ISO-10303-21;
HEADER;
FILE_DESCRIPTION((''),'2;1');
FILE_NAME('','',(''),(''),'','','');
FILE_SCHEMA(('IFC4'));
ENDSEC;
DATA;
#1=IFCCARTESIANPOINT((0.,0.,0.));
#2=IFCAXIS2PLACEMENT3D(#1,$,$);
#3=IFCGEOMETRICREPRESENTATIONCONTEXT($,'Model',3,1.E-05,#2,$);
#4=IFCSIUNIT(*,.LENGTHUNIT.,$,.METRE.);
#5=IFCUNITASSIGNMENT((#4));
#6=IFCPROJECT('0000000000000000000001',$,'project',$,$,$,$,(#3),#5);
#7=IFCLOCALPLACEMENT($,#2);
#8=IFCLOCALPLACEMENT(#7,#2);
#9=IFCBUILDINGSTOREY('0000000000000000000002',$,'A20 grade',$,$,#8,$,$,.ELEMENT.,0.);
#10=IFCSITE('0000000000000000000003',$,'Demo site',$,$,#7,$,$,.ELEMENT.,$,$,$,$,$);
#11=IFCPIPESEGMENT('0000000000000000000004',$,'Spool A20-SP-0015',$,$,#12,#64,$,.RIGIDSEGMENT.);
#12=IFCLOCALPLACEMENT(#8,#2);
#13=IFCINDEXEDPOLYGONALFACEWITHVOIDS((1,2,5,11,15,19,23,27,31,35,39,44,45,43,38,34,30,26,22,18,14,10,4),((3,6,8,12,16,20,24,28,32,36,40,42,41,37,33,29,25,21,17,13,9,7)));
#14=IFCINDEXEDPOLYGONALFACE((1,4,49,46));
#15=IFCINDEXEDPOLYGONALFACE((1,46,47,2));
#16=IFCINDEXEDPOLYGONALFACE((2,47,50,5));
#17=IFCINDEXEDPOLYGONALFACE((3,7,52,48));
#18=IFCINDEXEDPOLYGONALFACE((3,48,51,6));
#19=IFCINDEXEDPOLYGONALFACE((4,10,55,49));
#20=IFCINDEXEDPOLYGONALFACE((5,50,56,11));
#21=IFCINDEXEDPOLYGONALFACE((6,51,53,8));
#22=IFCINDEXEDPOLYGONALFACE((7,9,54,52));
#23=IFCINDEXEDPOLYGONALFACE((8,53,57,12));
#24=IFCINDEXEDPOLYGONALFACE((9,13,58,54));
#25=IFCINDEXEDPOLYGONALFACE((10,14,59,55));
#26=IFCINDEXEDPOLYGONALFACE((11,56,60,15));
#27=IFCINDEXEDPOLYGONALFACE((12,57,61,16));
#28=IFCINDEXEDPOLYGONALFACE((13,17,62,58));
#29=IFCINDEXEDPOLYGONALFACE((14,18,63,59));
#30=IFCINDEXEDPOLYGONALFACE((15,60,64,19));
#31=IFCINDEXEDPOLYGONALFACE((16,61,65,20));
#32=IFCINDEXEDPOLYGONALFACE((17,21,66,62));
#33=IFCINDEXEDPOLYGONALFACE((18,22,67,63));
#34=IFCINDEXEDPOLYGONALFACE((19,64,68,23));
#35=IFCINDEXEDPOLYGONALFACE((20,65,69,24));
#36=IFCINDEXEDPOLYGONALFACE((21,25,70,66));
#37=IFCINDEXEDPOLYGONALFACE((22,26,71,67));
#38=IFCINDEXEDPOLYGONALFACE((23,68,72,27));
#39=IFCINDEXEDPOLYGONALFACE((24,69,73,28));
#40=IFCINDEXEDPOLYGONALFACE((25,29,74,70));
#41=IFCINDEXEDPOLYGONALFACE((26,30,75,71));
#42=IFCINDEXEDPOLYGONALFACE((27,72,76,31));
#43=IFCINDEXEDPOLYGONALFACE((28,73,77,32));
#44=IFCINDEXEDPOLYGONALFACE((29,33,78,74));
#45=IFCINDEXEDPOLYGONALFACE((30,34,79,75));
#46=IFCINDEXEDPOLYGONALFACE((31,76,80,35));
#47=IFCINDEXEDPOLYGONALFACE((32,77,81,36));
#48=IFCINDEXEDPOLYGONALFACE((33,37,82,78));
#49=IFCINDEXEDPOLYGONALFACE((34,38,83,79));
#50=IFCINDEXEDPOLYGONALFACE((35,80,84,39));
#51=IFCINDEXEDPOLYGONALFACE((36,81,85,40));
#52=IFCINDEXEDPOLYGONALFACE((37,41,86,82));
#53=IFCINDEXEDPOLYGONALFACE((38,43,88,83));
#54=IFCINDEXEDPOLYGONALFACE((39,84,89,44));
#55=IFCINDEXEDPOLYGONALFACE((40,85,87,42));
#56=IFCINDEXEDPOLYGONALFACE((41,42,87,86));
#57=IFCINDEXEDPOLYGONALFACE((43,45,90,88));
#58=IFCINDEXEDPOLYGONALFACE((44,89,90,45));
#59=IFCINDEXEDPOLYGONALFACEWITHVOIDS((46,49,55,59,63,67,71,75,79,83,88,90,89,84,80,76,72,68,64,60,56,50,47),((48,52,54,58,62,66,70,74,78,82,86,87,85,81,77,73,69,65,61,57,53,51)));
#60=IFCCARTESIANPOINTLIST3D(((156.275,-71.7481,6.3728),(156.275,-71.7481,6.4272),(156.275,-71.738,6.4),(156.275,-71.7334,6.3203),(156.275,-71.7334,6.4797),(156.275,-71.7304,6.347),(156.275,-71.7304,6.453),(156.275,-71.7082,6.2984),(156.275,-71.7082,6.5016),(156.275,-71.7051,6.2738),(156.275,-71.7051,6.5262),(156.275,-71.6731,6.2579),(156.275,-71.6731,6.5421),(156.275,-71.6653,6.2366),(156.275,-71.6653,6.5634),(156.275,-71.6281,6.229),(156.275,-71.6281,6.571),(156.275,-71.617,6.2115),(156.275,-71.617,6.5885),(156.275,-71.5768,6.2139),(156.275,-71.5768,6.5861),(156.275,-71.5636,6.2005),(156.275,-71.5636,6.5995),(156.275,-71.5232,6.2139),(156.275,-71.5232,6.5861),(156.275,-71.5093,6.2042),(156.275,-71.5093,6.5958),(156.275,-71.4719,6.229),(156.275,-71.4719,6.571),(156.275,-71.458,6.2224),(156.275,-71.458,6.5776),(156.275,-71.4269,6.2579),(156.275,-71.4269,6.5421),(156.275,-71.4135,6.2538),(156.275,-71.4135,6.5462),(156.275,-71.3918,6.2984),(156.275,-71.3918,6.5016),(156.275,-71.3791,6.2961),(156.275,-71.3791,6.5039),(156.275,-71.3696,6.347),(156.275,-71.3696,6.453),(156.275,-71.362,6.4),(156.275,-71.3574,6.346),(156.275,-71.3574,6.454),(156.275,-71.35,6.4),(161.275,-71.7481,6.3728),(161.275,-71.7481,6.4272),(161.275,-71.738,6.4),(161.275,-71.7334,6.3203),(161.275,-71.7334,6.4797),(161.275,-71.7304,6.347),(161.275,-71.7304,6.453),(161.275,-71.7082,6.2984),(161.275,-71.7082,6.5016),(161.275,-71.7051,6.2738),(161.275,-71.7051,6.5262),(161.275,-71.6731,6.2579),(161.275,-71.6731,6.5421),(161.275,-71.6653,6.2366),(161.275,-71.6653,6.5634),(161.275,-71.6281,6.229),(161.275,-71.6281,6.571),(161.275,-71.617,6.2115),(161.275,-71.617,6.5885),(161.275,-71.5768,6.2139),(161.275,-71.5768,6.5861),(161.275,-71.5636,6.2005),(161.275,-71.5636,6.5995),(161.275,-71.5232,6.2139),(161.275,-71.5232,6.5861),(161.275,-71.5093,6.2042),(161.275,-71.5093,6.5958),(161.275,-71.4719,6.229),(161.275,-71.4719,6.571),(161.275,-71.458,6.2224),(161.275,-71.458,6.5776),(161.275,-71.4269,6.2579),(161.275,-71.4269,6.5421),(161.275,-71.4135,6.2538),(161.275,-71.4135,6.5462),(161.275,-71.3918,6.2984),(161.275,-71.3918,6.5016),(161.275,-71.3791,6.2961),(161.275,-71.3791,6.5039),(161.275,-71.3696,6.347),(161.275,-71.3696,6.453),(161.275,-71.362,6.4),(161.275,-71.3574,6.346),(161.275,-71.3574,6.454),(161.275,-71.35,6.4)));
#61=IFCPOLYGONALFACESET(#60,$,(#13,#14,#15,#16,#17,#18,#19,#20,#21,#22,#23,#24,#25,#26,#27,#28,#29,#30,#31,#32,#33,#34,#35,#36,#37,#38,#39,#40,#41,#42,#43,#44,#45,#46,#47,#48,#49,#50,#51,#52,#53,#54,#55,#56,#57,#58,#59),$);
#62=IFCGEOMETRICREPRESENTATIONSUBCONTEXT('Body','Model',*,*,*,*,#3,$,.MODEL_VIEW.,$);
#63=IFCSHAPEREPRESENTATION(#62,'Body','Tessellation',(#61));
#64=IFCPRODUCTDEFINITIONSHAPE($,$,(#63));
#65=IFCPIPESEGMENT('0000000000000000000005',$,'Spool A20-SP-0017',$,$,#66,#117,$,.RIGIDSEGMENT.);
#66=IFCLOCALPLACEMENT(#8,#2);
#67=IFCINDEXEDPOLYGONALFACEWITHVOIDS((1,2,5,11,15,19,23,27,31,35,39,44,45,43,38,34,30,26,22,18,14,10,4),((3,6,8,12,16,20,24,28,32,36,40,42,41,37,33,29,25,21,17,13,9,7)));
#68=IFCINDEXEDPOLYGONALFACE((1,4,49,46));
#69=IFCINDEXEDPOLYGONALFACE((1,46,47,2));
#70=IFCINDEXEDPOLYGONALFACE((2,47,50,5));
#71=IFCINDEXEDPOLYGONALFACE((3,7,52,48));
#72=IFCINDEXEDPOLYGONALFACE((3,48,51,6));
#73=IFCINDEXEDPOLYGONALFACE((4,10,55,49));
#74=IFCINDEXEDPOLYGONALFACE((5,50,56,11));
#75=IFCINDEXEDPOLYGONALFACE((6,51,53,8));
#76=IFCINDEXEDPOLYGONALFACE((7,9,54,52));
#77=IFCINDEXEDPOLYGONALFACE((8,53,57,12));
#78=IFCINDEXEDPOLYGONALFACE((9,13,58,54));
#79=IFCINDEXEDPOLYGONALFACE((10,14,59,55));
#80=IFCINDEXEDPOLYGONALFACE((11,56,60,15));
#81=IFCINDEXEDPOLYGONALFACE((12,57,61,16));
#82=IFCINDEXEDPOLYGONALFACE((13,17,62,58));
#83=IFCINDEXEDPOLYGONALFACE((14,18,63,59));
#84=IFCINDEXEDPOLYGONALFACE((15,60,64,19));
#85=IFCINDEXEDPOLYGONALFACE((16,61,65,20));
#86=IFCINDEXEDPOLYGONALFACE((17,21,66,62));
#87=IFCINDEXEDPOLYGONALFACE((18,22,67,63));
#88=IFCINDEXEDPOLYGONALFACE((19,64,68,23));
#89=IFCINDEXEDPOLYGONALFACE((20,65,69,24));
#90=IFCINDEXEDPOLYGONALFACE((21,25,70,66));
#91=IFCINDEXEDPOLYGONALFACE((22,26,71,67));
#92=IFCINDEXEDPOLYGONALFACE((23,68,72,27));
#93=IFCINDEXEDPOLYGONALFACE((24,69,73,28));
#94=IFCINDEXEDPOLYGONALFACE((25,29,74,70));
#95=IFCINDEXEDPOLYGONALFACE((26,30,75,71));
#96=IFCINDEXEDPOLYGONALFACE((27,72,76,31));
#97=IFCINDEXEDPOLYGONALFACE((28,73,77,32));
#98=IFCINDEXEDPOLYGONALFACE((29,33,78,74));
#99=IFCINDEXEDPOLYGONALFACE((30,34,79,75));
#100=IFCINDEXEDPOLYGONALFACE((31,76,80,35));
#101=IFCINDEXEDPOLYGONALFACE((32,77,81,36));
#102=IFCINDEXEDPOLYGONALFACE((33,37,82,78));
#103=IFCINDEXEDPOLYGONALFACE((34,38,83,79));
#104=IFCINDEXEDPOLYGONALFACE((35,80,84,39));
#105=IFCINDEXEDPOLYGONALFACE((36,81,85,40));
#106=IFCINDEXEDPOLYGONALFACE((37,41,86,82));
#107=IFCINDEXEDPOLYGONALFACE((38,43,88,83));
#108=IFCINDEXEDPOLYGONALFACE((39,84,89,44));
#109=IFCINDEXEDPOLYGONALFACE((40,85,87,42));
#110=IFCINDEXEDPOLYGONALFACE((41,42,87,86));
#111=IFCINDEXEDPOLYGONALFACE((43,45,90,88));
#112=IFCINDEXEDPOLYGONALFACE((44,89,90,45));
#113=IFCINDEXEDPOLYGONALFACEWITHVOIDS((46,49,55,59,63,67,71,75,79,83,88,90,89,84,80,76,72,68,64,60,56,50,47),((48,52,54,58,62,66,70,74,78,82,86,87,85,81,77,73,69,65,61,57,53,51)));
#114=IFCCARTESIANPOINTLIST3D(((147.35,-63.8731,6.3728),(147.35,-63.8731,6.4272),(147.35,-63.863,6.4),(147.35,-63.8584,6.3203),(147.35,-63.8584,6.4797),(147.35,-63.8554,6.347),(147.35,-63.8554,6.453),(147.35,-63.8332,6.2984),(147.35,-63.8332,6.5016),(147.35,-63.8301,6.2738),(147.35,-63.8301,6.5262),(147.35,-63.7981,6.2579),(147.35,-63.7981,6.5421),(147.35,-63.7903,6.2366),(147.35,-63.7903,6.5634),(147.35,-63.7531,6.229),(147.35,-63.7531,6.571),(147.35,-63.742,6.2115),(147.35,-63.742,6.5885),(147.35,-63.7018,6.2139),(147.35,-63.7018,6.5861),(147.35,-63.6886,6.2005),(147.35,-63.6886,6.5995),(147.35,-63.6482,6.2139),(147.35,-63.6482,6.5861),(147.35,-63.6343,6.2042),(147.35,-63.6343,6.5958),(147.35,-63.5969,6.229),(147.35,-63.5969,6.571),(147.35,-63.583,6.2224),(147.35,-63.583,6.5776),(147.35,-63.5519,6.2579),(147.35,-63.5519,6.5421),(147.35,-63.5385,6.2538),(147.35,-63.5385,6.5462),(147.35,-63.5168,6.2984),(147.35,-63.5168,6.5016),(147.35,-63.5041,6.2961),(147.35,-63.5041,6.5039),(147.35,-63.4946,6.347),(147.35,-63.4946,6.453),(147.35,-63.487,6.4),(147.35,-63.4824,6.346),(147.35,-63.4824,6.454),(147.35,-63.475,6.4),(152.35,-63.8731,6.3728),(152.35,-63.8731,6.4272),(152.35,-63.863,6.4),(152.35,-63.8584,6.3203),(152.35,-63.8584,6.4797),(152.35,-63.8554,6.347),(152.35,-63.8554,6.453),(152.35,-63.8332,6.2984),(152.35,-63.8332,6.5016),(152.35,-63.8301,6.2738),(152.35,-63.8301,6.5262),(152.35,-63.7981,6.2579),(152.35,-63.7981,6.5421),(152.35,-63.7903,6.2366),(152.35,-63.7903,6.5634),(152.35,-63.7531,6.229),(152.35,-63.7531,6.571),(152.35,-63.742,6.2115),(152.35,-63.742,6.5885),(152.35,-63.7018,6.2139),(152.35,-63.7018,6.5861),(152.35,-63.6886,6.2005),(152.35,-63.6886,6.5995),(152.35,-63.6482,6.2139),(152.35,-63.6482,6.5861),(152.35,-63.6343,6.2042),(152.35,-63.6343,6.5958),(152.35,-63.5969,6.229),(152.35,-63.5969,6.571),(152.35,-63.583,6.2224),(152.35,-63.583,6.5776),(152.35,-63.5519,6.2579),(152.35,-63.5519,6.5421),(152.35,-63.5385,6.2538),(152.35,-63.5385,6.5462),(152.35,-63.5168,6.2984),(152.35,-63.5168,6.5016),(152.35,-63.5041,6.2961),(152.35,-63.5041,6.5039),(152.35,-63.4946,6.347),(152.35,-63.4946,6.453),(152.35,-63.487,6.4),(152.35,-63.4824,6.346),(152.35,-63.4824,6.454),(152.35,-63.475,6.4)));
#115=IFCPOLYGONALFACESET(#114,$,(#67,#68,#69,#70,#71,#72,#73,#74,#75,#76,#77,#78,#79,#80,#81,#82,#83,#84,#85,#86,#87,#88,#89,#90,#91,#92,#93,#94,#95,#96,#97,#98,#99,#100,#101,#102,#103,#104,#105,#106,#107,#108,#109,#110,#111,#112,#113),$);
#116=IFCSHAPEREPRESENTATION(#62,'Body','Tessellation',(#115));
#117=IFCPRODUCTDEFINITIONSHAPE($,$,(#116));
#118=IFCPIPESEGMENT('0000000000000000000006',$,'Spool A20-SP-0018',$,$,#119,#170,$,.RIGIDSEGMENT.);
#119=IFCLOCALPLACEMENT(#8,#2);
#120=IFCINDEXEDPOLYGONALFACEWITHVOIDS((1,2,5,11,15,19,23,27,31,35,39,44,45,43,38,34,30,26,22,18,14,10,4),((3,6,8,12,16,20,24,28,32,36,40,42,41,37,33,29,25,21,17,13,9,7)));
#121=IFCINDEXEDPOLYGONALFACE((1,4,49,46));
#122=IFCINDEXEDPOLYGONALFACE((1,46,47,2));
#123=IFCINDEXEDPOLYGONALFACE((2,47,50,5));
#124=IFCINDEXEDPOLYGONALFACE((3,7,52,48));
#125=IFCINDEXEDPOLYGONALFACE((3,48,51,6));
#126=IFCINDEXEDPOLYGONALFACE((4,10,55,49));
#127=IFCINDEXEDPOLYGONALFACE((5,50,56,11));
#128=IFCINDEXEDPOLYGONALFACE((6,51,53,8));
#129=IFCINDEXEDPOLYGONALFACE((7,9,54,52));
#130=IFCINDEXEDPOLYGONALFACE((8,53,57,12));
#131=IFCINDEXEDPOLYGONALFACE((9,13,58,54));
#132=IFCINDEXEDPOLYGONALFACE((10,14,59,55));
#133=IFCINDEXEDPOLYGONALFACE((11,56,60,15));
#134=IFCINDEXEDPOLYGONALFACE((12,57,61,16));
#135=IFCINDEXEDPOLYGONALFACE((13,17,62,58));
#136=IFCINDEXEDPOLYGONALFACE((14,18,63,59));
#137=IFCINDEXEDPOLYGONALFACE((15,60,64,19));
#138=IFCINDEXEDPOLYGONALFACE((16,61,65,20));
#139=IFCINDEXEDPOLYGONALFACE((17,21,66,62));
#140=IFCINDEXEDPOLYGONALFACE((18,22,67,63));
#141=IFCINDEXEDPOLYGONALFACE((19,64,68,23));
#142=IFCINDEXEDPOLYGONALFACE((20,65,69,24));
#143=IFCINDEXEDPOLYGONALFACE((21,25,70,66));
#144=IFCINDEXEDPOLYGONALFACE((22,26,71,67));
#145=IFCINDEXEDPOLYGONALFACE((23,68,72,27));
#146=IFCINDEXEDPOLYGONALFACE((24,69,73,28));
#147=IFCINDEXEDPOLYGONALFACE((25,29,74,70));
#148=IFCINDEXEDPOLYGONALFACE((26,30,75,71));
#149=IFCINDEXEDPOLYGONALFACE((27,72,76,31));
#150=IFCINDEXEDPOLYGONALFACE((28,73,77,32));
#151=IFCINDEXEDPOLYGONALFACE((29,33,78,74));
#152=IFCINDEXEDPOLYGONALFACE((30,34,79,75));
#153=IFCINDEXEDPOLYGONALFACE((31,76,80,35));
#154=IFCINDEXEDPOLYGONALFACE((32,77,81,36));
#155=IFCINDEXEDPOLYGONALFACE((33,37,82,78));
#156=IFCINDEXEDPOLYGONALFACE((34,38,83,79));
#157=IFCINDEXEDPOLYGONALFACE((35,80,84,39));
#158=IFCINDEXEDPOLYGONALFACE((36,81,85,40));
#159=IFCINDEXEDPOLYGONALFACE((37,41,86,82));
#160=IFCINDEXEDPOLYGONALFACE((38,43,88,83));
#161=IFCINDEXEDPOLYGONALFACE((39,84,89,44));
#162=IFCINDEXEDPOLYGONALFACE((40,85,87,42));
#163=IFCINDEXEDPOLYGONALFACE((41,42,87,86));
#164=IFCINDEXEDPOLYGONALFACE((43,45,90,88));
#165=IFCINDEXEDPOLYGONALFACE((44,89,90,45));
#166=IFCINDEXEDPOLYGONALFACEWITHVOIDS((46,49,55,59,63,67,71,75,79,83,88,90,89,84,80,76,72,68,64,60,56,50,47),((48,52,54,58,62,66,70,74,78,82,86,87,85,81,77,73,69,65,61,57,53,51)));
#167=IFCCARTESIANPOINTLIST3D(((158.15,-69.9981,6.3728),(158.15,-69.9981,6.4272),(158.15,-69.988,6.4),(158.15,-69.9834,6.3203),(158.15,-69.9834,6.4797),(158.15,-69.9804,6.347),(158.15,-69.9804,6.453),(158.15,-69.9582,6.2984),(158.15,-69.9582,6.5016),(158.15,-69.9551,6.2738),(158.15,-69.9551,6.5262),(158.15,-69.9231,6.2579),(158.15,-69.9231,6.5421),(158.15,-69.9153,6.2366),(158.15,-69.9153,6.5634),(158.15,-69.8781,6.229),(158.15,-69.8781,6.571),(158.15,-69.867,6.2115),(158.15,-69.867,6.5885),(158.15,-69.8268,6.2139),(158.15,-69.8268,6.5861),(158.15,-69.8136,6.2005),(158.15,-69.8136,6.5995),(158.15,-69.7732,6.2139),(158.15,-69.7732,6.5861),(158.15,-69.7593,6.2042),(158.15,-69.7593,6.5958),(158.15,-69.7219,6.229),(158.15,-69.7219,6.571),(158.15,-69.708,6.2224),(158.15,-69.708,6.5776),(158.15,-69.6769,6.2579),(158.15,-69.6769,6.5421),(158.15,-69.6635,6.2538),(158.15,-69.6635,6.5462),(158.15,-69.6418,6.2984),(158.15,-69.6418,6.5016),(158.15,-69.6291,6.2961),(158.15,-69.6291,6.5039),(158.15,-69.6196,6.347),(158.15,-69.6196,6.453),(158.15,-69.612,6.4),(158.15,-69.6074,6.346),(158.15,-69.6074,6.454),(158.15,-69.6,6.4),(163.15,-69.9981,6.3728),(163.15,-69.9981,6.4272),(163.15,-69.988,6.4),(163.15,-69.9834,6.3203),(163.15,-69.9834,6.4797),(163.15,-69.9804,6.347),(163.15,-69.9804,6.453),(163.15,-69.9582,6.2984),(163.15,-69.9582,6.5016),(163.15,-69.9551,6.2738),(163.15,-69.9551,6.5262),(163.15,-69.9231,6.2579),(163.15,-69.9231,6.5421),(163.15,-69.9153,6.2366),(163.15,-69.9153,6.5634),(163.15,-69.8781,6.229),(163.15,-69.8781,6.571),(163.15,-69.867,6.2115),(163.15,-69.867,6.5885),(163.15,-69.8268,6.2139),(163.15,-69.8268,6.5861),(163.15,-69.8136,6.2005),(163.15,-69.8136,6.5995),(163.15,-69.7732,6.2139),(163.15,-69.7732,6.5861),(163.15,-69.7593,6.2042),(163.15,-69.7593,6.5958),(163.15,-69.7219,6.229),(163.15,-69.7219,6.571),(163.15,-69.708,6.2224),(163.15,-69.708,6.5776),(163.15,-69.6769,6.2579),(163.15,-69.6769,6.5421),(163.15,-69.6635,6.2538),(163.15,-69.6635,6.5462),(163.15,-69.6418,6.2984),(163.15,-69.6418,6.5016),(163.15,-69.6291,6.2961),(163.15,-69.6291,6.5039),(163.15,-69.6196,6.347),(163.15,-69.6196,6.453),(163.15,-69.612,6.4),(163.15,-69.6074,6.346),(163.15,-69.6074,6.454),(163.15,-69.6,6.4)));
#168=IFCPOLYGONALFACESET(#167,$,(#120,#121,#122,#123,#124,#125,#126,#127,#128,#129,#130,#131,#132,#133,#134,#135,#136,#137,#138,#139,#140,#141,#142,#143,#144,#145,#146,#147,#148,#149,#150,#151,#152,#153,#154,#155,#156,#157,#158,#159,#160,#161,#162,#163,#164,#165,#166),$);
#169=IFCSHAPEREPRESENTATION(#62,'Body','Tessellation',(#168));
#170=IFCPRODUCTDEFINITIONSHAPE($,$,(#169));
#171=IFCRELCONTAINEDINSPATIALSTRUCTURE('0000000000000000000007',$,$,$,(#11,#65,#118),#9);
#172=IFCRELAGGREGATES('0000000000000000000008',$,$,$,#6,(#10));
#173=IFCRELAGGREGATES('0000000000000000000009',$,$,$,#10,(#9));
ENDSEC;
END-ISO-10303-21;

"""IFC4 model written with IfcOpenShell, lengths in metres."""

from ifc_helpers import new_model, si_unit, frame, origin, place, context, subcontext, project, spatial, hollow_circle, extrude, element, save


model = new_model("IFC4")

# Units and contexts
model_context = context("Model", 3, precision=1e-05, world=origin())
body_context = subcontext(model_context, "Body", "Model", "MODEL_VIEW")
ifc_project = project(units=[si_unit("LENGTHUNIT", "METRE")], contexts=[model_context])

# Site, storey
site_placement = place(None, origin())
site = spatial("IfcSite", under=ifc_project, at=site_placement, Name="Demo site", CompositionType="ELEMENT")
storey_placement = place(site_placement, origin())
storey = spatial("IfcBuildingStorey", under=site, at=storey_placement, Name="A20 grade", CompositionType="ELEMENT", Elevation=0.0)

# Pipe segments
for number, where, name in (
    (1, (156.275, -71.55, 6.4), "Spool A20-SP-0015"),
    (2, (147.35, -63.675, 6.4), "Spool A20-SP-0017"),
    (3, (158.15, -69.8, 6.4), "Spool A20-SP-0018"),
):
    element("IfcPipeSegment", number, at=place(storey_placement, frame(where)), inside=storey, Name=name, PredefinedType="RIGIDSEGMENT", context=body_context, shape_type="SweptSolid", body=[
        extrude(hollow_circle(Radius=0.2, WallThickness=0.012), frame((0.0, 0.0, 0.0), z_axis=(1.0, 0.0, 0.0), x_axis=(0.0, 1.0, 0.0)), (0.0, 0.0, 1.0), 5.0),
    ])

save(model, "model.ifc")
